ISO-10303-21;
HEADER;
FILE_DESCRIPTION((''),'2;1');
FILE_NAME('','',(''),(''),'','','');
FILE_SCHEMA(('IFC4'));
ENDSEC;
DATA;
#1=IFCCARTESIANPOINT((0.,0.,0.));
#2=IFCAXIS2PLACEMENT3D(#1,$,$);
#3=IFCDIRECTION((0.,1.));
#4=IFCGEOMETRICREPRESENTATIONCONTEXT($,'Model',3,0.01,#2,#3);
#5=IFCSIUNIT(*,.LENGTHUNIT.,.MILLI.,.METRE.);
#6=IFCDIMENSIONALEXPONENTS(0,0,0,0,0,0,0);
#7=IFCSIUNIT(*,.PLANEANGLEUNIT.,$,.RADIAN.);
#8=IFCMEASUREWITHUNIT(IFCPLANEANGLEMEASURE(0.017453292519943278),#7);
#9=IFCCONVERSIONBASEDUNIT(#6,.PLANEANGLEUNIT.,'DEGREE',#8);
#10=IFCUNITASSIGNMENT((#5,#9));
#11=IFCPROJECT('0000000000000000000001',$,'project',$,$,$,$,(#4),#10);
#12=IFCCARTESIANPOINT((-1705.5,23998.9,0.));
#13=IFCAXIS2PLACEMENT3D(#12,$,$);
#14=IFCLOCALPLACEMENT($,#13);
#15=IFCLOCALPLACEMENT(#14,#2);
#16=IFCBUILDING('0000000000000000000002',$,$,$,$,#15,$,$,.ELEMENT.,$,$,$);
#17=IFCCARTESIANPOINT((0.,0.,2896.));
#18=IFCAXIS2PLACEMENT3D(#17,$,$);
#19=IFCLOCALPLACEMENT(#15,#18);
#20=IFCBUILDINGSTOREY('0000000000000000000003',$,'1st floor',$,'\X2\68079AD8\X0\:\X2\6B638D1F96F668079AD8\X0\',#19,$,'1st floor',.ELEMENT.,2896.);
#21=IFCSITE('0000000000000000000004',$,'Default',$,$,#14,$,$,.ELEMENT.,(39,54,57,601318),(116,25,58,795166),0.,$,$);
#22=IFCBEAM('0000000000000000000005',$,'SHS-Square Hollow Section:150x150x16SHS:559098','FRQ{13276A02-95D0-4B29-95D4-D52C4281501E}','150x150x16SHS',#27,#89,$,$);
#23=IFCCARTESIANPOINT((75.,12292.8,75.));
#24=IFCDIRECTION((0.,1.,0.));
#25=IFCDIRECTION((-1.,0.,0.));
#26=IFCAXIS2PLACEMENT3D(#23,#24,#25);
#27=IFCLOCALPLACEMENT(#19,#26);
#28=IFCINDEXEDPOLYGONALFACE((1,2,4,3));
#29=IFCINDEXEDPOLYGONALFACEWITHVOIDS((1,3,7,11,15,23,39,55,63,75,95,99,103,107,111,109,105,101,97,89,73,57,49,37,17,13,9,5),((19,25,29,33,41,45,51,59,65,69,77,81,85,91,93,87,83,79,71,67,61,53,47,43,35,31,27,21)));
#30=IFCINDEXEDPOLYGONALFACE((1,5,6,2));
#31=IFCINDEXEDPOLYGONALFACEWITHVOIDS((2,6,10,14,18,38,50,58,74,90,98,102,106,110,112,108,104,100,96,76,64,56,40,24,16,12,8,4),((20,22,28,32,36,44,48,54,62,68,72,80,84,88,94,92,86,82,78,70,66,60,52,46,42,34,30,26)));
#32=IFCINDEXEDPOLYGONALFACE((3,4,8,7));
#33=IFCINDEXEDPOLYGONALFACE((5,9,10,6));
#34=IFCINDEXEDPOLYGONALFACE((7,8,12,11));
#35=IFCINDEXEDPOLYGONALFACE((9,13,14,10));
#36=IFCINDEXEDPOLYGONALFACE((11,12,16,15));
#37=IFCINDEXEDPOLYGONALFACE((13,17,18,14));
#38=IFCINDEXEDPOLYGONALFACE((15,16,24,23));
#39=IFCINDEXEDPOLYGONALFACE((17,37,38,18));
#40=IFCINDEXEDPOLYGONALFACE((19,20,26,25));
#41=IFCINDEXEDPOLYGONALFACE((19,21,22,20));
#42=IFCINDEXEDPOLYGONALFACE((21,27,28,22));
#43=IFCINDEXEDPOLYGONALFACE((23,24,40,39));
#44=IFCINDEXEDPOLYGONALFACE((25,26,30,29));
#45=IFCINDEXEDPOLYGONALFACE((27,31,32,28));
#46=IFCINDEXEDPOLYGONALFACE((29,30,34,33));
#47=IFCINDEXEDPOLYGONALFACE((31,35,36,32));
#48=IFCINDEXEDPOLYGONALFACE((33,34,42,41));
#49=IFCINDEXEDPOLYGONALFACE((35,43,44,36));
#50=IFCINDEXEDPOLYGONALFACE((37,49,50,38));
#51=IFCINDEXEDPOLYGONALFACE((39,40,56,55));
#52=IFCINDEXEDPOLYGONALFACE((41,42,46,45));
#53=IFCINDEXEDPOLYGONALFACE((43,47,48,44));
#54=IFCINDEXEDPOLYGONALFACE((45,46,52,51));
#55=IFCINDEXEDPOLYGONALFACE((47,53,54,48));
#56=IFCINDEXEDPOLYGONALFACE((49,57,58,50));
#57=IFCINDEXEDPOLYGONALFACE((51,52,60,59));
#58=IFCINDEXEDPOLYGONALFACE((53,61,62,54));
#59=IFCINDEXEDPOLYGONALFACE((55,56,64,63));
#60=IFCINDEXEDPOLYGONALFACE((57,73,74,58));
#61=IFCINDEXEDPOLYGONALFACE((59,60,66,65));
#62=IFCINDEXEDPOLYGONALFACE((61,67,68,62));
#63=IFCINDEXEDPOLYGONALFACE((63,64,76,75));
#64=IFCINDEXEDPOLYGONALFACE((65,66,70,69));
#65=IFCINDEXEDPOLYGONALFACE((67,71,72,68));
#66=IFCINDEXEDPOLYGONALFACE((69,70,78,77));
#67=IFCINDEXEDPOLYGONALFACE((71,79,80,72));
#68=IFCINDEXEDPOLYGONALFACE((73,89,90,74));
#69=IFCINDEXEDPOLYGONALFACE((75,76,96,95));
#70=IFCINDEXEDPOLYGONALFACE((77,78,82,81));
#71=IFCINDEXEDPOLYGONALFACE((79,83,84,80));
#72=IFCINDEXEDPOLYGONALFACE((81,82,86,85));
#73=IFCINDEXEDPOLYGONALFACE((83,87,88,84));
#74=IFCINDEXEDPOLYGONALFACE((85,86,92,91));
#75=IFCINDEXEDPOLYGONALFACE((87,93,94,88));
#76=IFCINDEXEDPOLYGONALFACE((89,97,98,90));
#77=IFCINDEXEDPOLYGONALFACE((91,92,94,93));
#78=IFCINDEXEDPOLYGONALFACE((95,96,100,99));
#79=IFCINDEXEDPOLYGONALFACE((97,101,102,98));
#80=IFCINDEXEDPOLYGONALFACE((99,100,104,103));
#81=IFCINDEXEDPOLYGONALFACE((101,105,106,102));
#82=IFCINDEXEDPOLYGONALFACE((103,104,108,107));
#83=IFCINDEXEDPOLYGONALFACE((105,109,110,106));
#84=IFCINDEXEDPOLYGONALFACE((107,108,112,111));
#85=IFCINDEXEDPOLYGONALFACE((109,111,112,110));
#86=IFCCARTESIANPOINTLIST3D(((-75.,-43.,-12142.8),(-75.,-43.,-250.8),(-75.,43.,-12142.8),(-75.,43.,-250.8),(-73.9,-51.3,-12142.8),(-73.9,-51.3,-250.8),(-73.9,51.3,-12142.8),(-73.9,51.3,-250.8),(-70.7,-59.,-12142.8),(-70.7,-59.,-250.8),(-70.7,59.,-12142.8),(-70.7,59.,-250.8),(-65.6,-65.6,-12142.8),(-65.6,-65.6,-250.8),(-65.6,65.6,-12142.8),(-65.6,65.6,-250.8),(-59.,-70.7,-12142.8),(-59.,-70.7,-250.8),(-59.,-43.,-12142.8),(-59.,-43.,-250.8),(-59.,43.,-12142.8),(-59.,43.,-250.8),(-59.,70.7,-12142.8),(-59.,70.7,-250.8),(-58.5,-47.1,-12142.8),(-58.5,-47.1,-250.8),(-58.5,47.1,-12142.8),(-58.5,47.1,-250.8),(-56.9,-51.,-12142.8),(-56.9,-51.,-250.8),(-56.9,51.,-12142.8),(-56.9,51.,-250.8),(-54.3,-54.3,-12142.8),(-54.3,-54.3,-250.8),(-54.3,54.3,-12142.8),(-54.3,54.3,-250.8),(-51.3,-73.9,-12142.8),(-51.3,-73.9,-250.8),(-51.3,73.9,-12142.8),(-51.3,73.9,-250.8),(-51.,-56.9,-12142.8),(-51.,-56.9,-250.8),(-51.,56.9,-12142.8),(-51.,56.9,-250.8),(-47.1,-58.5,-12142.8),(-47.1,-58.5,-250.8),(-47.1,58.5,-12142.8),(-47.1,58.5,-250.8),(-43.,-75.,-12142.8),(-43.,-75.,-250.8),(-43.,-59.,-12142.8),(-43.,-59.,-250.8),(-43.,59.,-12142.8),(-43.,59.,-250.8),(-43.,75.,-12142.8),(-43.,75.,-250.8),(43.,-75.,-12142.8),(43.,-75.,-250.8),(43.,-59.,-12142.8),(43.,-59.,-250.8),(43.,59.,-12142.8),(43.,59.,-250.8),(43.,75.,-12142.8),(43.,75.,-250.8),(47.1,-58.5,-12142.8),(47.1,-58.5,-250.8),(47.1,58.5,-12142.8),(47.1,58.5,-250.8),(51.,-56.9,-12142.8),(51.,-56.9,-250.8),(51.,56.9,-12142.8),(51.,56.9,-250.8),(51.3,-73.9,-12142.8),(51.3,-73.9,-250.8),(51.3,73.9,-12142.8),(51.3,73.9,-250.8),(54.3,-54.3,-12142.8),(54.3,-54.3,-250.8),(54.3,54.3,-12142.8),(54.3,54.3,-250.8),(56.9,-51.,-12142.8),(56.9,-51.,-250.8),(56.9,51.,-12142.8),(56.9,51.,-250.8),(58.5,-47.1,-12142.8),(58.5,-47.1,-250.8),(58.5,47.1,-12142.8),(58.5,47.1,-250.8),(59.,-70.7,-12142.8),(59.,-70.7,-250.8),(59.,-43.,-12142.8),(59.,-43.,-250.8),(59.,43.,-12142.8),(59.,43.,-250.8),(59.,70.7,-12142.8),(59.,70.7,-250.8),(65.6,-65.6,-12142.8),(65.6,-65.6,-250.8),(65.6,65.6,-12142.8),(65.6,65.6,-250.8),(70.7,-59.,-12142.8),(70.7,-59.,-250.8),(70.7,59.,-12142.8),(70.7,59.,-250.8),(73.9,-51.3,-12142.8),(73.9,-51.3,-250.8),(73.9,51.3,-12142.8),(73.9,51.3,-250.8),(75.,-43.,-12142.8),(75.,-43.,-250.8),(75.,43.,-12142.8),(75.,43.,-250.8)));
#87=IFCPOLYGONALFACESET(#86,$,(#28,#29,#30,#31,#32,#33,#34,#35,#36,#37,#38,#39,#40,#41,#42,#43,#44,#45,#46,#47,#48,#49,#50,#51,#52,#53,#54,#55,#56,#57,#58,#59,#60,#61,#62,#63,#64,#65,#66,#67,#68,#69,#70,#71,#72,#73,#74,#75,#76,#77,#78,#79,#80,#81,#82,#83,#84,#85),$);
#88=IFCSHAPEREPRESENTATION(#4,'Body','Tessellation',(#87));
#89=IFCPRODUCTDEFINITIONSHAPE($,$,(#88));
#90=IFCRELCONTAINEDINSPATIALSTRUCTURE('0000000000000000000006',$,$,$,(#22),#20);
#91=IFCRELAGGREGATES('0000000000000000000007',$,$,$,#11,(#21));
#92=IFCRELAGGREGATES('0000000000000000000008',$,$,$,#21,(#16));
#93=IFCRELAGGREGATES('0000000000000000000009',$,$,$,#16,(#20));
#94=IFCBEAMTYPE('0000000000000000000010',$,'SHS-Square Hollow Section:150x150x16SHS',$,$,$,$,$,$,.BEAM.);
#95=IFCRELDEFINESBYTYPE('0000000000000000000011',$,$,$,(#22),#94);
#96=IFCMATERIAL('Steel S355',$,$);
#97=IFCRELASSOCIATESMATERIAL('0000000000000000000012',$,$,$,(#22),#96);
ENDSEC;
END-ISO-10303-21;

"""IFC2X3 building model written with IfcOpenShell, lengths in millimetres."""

from ifc_helpers import new_model, entity, si_unit, converted_unit, direction, frame, origin, origin_2d, place, context, project, spatial, hollow_rectangle, extrude, clip, halfspace, material, type_object, element, save


model = new_model("IFC2X3")

# Units and contexts
model_context = context("Model", 3, precision=0.01, world=origin(), true_north=direction((0.0, 1.0)))
ifc_project = project(units=[si_unit("LENGTHUNIT", "METRE", prefix="MILLI"), converted_unit("PLANEANGLEUNIT", "DEGREE", entity("IfcPlaneAngleMeasure", 0.017453292519943278), si_unit("PLANEANGLEUNIT", "RADIAN"), dimensions=[0, 0, 0, 0, 0, 0, 0])], contexts=[model_context])

# Site, building, storey
site_placement = place(None, frame((-1705.5, 23998.9, 0.0)))
site = spatial("IfcSite", under=ifc_project, at=site_placement, Name="Default", CompositionType="ELEMENT", RefLatitude=(39, 54, 57, 601318), RefLongitude=(116, 25, 58, 795166), RefElevation=0.0)
building_placement = place(site_placement, origin())
building = spatial("IfcBuilding", under=site, at=building_placement, CompositionType="ELEMENT")
storey_placement = place(building_placement, frame((0.0, 0.0, 2896.0)))
storey = spatial("IfcBuildingStorey", under=building, at=storey_placement, Name="1st floor", ObjectType="标高:正负零标高", LongName="1st floor", CompositionType="ELEMENT", Elevation=2896.0)

# Shared definitions
ifc_material_1 = material(Name="Steel S355")

# Beam
beam_type_1 = type_object("IfcBeamType", Name="SHS-Square Hollow Section:150x150x16SHS", PredefinedType="BEAM")
beam_1_placement = place(storey_placement, frame((75.0, 12292.8, 75.0), z_axis=(0.0, 1.0, 0.0), x_axis=(-1.0, 0.0, 0.0)))
element("IfcBeam", 1, at=beam_1_placement, inside=storey, type_object=beam_type_1, material=ifc_material_1, Name="SHS-Square Hollow Section:150x150x16SHS:559098", Description="FRQ{13276A02-95D0-4B29-95D4-D52C4281501E}", ObjectType="150x150x16SHS", context=model_context, shape_type="Clipping", body=[
    clip(clip(extrude(hollow_rectangle(XDim=150.0, YDim=150.0, WallThickness=16.0, InnerFilletRadius=16.0, OuterFilletRadius=32.0, at=origin_2d()), origin(), (0.0, 0.0, -1.0), 12398.9), halfspace(frame((75.0, -2971.0, -12142.8), z_axis=(0.0, 0.0, 1.0), x_axis=(1.0, 0.0, 0.0)), True)), halfspace(frame((75.0, -2971.0, -250.8), z_axis=(0.0, 0.0, -1.0), x_axis=(-1.0, 0.0, 0.0)), True)),
])

save(model, "model.ifc")
